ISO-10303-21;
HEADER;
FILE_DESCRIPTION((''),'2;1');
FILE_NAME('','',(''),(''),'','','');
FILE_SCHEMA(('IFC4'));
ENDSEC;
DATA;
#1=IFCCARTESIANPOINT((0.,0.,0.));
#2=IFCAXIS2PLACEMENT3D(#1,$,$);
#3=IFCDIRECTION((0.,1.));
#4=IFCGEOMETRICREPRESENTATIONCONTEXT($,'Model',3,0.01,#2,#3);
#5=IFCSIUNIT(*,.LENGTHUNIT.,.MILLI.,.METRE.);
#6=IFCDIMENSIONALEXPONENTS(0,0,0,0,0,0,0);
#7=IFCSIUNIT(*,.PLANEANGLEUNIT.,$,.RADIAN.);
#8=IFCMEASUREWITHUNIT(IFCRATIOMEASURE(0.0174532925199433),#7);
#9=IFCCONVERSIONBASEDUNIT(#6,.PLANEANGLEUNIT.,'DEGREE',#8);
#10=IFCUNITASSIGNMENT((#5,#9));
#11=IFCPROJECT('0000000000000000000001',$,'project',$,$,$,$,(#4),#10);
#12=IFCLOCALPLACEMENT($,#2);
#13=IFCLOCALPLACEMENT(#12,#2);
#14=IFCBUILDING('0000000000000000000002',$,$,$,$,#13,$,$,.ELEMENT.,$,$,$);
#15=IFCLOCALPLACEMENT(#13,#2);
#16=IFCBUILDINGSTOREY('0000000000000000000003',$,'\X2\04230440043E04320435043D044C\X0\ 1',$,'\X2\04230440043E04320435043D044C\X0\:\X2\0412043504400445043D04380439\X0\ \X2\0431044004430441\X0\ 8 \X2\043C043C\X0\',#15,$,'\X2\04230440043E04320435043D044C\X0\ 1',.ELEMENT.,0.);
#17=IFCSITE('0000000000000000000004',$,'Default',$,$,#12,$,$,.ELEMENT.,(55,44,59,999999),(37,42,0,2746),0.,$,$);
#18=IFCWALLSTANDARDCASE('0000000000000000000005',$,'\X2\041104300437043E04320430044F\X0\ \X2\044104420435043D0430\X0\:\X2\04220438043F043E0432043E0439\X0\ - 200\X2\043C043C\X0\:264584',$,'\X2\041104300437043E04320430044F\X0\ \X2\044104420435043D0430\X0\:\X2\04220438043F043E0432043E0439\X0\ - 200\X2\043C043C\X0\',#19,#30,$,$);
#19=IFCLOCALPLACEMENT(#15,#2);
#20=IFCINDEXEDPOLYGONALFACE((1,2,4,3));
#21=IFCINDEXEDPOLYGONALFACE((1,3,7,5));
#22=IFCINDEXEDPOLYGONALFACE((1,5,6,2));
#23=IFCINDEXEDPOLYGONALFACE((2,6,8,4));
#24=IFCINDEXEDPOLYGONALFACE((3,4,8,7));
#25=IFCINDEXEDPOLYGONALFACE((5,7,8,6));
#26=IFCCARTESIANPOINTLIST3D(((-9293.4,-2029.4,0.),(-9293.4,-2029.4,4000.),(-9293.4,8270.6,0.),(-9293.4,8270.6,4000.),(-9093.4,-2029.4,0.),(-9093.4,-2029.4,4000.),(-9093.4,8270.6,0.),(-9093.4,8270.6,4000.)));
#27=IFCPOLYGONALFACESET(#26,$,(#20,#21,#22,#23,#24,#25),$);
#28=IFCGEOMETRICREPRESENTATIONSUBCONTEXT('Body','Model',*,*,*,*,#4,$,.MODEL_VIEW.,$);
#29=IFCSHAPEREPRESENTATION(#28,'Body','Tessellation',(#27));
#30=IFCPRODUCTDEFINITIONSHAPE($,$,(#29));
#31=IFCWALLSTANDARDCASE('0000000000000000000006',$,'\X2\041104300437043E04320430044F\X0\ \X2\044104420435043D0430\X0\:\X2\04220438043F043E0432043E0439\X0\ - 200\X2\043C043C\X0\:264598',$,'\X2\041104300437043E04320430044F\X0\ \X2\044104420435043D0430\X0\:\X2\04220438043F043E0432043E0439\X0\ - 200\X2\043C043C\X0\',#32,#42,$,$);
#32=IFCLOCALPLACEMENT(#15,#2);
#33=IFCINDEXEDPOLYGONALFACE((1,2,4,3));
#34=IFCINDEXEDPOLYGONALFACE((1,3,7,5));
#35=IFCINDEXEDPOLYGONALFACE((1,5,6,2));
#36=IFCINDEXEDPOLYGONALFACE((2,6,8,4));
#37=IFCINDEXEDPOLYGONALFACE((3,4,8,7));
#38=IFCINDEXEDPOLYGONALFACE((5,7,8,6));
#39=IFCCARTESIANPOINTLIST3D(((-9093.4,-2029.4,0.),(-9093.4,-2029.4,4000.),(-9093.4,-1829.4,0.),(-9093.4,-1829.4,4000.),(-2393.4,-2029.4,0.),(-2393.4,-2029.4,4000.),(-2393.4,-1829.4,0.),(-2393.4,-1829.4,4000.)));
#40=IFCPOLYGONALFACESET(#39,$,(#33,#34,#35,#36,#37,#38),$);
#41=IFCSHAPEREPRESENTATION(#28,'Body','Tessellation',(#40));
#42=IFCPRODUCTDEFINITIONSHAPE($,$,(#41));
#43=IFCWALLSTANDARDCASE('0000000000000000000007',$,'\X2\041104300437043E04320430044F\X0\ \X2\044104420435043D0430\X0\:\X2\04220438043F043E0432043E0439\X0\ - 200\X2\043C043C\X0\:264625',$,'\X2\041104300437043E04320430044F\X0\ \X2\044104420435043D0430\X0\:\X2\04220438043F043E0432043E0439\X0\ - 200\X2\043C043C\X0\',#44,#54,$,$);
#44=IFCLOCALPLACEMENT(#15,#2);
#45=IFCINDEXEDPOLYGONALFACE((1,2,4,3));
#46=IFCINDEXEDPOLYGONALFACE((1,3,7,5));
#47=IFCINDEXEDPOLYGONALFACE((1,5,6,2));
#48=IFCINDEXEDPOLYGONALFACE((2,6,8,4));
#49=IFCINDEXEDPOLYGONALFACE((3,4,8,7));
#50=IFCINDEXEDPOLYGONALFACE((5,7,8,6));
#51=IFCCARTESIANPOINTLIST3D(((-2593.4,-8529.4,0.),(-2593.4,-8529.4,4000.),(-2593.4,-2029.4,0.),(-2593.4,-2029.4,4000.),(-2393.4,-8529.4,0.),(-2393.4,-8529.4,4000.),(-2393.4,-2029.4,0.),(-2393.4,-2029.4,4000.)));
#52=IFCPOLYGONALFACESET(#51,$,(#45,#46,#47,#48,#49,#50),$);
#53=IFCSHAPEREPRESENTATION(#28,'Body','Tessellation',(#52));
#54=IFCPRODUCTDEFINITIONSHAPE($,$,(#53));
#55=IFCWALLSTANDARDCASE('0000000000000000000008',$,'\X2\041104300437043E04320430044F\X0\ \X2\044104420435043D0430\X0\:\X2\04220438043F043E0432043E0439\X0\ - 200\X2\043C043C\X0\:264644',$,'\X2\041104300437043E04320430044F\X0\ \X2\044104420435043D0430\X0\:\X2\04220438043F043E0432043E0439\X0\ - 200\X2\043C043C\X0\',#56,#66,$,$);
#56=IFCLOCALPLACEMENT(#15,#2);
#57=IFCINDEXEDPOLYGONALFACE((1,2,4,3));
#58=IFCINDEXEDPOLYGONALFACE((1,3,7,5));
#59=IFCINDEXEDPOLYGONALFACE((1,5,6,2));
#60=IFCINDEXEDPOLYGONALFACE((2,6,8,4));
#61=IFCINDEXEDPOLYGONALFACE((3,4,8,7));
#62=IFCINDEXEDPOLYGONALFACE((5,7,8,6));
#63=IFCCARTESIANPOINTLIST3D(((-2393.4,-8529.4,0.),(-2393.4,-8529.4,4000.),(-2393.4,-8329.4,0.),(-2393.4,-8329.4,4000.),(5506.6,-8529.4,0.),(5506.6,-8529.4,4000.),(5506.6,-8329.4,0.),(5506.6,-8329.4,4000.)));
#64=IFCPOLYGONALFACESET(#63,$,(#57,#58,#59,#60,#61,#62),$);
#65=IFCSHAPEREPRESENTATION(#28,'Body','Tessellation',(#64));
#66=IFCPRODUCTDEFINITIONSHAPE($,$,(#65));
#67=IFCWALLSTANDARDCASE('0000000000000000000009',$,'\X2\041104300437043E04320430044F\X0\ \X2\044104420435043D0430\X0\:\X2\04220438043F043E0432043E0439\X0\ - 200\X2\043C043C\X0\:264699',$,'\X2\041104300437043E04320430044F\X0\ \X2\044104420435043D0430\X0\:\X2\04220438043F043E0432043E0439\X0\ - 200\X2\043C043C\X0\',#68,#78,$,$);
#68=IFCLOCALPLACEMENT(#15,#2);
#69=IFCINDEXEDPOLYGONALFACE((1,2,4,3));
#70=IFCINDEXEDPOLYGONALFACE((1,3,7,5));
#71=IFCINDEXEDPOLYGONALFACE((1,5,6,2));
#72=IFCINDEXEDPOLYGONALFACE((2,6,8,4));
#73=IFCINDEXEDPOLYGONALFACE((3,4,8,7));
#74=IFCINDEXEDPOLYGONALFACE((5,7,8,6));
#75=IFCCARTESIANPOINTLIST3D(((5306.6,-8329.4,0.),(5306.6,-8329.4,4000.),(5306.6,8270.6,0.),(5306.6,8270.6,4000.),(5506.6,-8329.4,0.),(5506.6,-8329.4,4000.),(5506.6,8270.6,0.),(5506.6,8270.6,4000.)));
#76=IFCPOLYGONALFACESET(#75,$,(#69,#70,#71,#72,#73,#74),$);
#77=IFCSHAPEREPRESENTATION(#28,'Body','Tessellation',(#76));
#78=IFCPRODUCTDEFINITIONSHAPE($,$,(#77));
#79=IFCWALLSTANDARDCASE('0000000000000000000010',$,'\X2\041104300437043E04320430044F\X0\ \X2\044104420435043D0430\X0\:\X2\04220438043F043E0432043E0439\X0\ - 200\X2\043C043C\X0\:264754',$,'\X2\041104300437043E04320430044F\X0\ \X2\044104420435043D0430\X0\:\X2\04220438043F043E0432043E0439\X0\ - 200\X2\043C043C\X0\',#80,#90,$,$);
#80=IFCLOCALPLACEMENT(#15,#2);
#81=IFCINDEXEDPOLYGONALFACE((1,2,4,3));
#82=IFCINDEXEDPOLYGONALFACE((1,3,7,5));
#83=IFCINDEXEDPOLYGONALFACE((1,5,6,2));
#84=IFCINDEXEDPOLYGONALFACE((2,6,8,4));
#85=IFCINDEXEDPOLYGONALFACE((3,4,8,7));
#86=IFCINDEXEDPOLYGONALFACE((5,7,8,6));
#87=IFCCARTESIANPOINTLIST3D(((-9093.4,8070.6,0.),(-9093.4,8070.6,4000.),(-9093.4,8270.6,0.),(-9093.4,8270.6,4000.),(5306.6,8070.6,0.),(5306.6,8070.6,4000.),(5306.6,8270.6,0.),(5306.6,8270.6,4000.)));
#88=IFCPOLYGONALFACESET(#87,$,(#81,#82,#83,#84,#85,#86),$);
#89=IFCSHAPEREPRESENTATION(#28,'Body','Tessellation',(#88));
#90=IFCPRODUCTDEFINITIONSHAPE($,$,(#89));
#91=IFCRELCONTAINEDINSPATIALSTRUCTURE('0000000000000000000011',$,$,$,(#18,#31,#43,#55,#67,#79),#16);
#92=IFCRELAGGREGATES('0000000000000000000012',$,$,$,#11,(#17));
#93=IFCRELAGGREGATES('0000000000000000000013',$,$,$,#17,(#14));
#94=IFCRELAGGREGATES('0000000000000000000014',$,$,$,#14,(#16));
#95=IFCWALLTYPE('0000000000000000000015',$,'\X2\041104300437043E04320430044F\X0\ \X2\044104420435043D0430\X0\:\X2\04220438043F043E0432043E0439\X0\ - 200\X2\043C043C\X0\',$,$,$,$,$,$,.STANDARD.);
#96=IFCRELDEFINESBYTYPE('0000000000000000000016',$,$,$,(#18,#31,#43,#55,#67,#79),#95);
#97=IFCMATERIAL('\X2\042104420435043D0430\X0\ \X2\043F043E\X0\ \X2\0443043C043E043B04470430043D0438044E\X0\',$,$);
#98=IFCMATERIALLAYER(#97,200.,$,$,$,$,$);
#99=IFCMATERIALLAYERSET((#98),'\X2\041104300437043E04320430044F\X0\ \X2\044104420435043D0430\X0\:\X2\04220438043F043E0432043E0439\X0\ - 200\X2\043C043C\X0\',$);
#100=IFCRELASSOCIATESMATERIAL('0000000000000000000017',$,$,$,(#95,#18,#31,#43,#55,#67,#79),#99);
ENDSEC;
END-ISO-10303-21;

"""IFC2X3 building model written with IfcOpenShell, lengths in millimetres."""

from ifc_helpers import new_model, entity, si_unit, converted_unit, direction, frame, frame_2d, origin, place, context, subcontext, project, spatial, rectangle, extrude, clip, halfspace, material, layer, layer_set, layer_usage, type_object, element, save


model = new_model("IFC2X3")

# Units and contexts
model_context = context("Model", 3, precision=0.01, world=origin(), true_north=direction((0.0, 1.0)))
body_context = subcontext(model_context, "Body", "Model", "MODEL_VIEW")
ifc_project = project(units=[si_unit("LENGTHUNIT", "METRE", prefix="MILLI"), converted_unit("PLANEANGLEUNIT", "DEGREE", entity("IfcRatioMeasure", 0.0174532925199433), si_unit("PLANEANGLEUNIT", "RADIAN"), dimensions=[0, 0, 0, 0, 0, 0, 0])], contexts=[model_context])

# Site, building, storey
site_placement = place(None, origin())
site = spatial("IfcSite", under=ifc_project, at=site_placement, Name="Default", CompositionType="ELEMENT", RefLatitude=(55, 44, 59, 999999), RefLongitude=(37, 42, 0, 2746), RefElevation=0.0)
building_placement = place(site_placement, origin())
building = spatial("IfcBuilding", under=site, at=building_placement, CompositionType="ELEMENT")
storey_placement = place(building_placement, origin())
storey = spatial("IfcBuildingStorey", under=building, at=storey_placement, Name="Уровень 1", ObjectType="Уровень:Верхний брус 8 мм", LongName="Уровень 1", CompositionType="ELEMENT", Elevation=0.0)

# Walls
ifc_material_1 = material(Name="Стена по умолчанию")
ifc_layer_1 = layer(ifc_material_1, 200.0)
ifc_layer_set_1 = layer_set([ifc_layer_1], Name="Базовая стена:Типовой - 200мм")
ifc_layer_usage_1 = layer_usage(ifc_layer_set_1, "AXIS2", "NEGATIVE", 100.0)
wall_type = type_object("IfcWallType", Name="Базовая стена:Типовой - 200мм", PredefinedType="STANDARD", material=ifc_layer_set_1)
wall_1_placement = place(storey_placement, frame((-9193.4, 8270.6, 0.0), z_axis=(0.0, 0.0, 1.0), x_axis=(0.0, -1.0, 0.0)))
element("IfcWallStandardCase", 1, at=wall_1_placement, inside=storey, type_object=wall_type, material=ifc_layer_usage_1, Name="Базовая стена:Типовой - 200мм:264584", ObjectType="Базовая стена:Типовой - 200мм", context=body_context, shape_type="Clipping", body=[
    clip(extrude(rectangle(XDim=10300.0, YDim=200.0, at=frame_2d((5150.0, 0.0), x_axis=(-1.0, 0.0))), origin(), (0.0, 0.0, 1.0), 4000.0), halfspace(frame((0.0, 0.0, -4600.0)), True)),
])
ifc_layer_usage_2 = layer_usage(ifc_layer_set_1, "AXIS2", "NEGATIVE", 100.0)
wall_2_placement = place(storey_placement, frame((-9093.4, -1929.4, 0.0)))
element("IfcWallStandardCase", 2, at=wall_2_placement, inside=storey, type_object=wall_type, material=ifc_layer_usage_2, Name="Базовая стена:Типовой - 200мм:264598", ObjectType="Базовая стена:Типовой - 200мм", context=body_context, shape_type="Clipping", body=[
    clip(extrude(rectangle(XDim=6700.0, YDim=200.0, at=frame_2d((3350.0, 0.0), x_axis=(-1.0, 0.0))), origin(), (0.0, 0.0, 1.0), 4000.0), halfspace(frame((0.0, 0.0, -4600.0)), True)),
])
ifc_layer_usage_3 = layer_usage(ifc_layer_set_1, "AXIS2", "NEGATIVE", 100.0)
wall_3_placement = place(storey_placement, frame((-2493.4, -2029.4, 0.0), z_axis=(0.0, 0.0, 1.0), x_axis=(0.0, -1.0, 0.0)))
element("IfcWallStandardCase", 3, at=wall_3_placement, inside=storey, type_object=wall_type, material=ifc_layer_usage_3, Name="Базовая стена:Типовой - 200мм:264625", ObjectType="Базовая стена:Типовой - 200мм", context=body_context, shape_type="Clipping", body=[
    clip(extrude(rectangle(XDim=6500.0, YDim=200.0, at=frame_2d((3250.0, 0.0), x_axis=(-1.0, 0.0))), origin(), (0.0, 0.0, 1.0), 4000.0), halfspace(frame((0.0, 0.0, -4600.0)), True)),
])
ifc_layer_usage_4 = layer_usage(ifc_layer_set_1, "AXIS2", "NEGATIVE", 100.0)
wall_4_placement = place(storey_placement, frame((-2393.4, -8429.4, 0.0)))
element("IfcWallStandardCase", 4, at=wall_4_placement, inside=storey, type_object=wall_type, material=ifc_layer_usage_4, Name="Базовая стена:Типовой - 200мм:264644", ObjectType="Базовая стена:Типовой - 200мм", context=body_context, shape_type="Clipping", body=[
    clip(extrude(rectangle(XDim=7900.0, YDim=200.0, at=frame_2d((3950.0, 0.0), x_axis=(-1.0, 0.0))), origin(), (0.0, 0.0, 1.0), 4000.0), halfspace(frame((0.0, 0.0, -4600.0)), True)),
])
ifc_layer_usage_5 = layer_usage(ifc_layer_set_1, "AXIS2", "NEGATIVE", 100.0)
wall_5_placement = place(storey_placement, frame((5406.6, -8329.4, 0.0), z_axis=(0.0, 0.0, 1.0), x_axis=(0.0, 1.0, 0.0)))
element("IfcWallStandardCase", 5, at=wall_5_placement, inside=storey, type_object=wall_type, material=ifc_layer_usage_5, Name="Базовая стена:Типовой - 200мм:264699", ObjectType="Базовая стена:Типовой - 200мм", context=body_context, shape_type="Clipping", body=[
    clip(extrude(rectangle(XDim=16600.0, YDim=200.0, at=frame_2d((8300.0, 0.0), x_axis=(-1.0, 0.0))), origin(), (0.0, 0.0, 1.0), 4000.0), halfspace(frame((0.0, 0.0, -4600.0)), True)),
])
ifc_layer_usage_6 = layer_usage(ifc_layer_set_1, "AXIS2", "NEGATIVE", 100.0)
wall_6_placement = place(storey_placement, frame((5306.6, 8170.6, 0.0), z_axis=(0.0, 0.0, 1.0), x_axis=(-1.0, 0.0, 0.0)))
element("IfcWallStandardCase", 6, at=wall_6_placement, inside=storey, type_object=wall_type, material=ifc_layer_usage_6, Name="Базовая стена:Типовой - 200мм:264754", ObjectType="Базовая стена:Типовой - 200мм", context=body_context, shape_type="Clipping", body=[
    clip(extrude(rectangle(XDim=14400.0, YDim=200.0, at=frame_2d((7200.0, 0.0), x_axis=(-1.0, 0.0))), origin(), (0.0, 0.0, 1.0), 4000.0), halfspace(frame((0.0, 0.0, -4600.0)), True)),
])

save(model, "model.ifc")
